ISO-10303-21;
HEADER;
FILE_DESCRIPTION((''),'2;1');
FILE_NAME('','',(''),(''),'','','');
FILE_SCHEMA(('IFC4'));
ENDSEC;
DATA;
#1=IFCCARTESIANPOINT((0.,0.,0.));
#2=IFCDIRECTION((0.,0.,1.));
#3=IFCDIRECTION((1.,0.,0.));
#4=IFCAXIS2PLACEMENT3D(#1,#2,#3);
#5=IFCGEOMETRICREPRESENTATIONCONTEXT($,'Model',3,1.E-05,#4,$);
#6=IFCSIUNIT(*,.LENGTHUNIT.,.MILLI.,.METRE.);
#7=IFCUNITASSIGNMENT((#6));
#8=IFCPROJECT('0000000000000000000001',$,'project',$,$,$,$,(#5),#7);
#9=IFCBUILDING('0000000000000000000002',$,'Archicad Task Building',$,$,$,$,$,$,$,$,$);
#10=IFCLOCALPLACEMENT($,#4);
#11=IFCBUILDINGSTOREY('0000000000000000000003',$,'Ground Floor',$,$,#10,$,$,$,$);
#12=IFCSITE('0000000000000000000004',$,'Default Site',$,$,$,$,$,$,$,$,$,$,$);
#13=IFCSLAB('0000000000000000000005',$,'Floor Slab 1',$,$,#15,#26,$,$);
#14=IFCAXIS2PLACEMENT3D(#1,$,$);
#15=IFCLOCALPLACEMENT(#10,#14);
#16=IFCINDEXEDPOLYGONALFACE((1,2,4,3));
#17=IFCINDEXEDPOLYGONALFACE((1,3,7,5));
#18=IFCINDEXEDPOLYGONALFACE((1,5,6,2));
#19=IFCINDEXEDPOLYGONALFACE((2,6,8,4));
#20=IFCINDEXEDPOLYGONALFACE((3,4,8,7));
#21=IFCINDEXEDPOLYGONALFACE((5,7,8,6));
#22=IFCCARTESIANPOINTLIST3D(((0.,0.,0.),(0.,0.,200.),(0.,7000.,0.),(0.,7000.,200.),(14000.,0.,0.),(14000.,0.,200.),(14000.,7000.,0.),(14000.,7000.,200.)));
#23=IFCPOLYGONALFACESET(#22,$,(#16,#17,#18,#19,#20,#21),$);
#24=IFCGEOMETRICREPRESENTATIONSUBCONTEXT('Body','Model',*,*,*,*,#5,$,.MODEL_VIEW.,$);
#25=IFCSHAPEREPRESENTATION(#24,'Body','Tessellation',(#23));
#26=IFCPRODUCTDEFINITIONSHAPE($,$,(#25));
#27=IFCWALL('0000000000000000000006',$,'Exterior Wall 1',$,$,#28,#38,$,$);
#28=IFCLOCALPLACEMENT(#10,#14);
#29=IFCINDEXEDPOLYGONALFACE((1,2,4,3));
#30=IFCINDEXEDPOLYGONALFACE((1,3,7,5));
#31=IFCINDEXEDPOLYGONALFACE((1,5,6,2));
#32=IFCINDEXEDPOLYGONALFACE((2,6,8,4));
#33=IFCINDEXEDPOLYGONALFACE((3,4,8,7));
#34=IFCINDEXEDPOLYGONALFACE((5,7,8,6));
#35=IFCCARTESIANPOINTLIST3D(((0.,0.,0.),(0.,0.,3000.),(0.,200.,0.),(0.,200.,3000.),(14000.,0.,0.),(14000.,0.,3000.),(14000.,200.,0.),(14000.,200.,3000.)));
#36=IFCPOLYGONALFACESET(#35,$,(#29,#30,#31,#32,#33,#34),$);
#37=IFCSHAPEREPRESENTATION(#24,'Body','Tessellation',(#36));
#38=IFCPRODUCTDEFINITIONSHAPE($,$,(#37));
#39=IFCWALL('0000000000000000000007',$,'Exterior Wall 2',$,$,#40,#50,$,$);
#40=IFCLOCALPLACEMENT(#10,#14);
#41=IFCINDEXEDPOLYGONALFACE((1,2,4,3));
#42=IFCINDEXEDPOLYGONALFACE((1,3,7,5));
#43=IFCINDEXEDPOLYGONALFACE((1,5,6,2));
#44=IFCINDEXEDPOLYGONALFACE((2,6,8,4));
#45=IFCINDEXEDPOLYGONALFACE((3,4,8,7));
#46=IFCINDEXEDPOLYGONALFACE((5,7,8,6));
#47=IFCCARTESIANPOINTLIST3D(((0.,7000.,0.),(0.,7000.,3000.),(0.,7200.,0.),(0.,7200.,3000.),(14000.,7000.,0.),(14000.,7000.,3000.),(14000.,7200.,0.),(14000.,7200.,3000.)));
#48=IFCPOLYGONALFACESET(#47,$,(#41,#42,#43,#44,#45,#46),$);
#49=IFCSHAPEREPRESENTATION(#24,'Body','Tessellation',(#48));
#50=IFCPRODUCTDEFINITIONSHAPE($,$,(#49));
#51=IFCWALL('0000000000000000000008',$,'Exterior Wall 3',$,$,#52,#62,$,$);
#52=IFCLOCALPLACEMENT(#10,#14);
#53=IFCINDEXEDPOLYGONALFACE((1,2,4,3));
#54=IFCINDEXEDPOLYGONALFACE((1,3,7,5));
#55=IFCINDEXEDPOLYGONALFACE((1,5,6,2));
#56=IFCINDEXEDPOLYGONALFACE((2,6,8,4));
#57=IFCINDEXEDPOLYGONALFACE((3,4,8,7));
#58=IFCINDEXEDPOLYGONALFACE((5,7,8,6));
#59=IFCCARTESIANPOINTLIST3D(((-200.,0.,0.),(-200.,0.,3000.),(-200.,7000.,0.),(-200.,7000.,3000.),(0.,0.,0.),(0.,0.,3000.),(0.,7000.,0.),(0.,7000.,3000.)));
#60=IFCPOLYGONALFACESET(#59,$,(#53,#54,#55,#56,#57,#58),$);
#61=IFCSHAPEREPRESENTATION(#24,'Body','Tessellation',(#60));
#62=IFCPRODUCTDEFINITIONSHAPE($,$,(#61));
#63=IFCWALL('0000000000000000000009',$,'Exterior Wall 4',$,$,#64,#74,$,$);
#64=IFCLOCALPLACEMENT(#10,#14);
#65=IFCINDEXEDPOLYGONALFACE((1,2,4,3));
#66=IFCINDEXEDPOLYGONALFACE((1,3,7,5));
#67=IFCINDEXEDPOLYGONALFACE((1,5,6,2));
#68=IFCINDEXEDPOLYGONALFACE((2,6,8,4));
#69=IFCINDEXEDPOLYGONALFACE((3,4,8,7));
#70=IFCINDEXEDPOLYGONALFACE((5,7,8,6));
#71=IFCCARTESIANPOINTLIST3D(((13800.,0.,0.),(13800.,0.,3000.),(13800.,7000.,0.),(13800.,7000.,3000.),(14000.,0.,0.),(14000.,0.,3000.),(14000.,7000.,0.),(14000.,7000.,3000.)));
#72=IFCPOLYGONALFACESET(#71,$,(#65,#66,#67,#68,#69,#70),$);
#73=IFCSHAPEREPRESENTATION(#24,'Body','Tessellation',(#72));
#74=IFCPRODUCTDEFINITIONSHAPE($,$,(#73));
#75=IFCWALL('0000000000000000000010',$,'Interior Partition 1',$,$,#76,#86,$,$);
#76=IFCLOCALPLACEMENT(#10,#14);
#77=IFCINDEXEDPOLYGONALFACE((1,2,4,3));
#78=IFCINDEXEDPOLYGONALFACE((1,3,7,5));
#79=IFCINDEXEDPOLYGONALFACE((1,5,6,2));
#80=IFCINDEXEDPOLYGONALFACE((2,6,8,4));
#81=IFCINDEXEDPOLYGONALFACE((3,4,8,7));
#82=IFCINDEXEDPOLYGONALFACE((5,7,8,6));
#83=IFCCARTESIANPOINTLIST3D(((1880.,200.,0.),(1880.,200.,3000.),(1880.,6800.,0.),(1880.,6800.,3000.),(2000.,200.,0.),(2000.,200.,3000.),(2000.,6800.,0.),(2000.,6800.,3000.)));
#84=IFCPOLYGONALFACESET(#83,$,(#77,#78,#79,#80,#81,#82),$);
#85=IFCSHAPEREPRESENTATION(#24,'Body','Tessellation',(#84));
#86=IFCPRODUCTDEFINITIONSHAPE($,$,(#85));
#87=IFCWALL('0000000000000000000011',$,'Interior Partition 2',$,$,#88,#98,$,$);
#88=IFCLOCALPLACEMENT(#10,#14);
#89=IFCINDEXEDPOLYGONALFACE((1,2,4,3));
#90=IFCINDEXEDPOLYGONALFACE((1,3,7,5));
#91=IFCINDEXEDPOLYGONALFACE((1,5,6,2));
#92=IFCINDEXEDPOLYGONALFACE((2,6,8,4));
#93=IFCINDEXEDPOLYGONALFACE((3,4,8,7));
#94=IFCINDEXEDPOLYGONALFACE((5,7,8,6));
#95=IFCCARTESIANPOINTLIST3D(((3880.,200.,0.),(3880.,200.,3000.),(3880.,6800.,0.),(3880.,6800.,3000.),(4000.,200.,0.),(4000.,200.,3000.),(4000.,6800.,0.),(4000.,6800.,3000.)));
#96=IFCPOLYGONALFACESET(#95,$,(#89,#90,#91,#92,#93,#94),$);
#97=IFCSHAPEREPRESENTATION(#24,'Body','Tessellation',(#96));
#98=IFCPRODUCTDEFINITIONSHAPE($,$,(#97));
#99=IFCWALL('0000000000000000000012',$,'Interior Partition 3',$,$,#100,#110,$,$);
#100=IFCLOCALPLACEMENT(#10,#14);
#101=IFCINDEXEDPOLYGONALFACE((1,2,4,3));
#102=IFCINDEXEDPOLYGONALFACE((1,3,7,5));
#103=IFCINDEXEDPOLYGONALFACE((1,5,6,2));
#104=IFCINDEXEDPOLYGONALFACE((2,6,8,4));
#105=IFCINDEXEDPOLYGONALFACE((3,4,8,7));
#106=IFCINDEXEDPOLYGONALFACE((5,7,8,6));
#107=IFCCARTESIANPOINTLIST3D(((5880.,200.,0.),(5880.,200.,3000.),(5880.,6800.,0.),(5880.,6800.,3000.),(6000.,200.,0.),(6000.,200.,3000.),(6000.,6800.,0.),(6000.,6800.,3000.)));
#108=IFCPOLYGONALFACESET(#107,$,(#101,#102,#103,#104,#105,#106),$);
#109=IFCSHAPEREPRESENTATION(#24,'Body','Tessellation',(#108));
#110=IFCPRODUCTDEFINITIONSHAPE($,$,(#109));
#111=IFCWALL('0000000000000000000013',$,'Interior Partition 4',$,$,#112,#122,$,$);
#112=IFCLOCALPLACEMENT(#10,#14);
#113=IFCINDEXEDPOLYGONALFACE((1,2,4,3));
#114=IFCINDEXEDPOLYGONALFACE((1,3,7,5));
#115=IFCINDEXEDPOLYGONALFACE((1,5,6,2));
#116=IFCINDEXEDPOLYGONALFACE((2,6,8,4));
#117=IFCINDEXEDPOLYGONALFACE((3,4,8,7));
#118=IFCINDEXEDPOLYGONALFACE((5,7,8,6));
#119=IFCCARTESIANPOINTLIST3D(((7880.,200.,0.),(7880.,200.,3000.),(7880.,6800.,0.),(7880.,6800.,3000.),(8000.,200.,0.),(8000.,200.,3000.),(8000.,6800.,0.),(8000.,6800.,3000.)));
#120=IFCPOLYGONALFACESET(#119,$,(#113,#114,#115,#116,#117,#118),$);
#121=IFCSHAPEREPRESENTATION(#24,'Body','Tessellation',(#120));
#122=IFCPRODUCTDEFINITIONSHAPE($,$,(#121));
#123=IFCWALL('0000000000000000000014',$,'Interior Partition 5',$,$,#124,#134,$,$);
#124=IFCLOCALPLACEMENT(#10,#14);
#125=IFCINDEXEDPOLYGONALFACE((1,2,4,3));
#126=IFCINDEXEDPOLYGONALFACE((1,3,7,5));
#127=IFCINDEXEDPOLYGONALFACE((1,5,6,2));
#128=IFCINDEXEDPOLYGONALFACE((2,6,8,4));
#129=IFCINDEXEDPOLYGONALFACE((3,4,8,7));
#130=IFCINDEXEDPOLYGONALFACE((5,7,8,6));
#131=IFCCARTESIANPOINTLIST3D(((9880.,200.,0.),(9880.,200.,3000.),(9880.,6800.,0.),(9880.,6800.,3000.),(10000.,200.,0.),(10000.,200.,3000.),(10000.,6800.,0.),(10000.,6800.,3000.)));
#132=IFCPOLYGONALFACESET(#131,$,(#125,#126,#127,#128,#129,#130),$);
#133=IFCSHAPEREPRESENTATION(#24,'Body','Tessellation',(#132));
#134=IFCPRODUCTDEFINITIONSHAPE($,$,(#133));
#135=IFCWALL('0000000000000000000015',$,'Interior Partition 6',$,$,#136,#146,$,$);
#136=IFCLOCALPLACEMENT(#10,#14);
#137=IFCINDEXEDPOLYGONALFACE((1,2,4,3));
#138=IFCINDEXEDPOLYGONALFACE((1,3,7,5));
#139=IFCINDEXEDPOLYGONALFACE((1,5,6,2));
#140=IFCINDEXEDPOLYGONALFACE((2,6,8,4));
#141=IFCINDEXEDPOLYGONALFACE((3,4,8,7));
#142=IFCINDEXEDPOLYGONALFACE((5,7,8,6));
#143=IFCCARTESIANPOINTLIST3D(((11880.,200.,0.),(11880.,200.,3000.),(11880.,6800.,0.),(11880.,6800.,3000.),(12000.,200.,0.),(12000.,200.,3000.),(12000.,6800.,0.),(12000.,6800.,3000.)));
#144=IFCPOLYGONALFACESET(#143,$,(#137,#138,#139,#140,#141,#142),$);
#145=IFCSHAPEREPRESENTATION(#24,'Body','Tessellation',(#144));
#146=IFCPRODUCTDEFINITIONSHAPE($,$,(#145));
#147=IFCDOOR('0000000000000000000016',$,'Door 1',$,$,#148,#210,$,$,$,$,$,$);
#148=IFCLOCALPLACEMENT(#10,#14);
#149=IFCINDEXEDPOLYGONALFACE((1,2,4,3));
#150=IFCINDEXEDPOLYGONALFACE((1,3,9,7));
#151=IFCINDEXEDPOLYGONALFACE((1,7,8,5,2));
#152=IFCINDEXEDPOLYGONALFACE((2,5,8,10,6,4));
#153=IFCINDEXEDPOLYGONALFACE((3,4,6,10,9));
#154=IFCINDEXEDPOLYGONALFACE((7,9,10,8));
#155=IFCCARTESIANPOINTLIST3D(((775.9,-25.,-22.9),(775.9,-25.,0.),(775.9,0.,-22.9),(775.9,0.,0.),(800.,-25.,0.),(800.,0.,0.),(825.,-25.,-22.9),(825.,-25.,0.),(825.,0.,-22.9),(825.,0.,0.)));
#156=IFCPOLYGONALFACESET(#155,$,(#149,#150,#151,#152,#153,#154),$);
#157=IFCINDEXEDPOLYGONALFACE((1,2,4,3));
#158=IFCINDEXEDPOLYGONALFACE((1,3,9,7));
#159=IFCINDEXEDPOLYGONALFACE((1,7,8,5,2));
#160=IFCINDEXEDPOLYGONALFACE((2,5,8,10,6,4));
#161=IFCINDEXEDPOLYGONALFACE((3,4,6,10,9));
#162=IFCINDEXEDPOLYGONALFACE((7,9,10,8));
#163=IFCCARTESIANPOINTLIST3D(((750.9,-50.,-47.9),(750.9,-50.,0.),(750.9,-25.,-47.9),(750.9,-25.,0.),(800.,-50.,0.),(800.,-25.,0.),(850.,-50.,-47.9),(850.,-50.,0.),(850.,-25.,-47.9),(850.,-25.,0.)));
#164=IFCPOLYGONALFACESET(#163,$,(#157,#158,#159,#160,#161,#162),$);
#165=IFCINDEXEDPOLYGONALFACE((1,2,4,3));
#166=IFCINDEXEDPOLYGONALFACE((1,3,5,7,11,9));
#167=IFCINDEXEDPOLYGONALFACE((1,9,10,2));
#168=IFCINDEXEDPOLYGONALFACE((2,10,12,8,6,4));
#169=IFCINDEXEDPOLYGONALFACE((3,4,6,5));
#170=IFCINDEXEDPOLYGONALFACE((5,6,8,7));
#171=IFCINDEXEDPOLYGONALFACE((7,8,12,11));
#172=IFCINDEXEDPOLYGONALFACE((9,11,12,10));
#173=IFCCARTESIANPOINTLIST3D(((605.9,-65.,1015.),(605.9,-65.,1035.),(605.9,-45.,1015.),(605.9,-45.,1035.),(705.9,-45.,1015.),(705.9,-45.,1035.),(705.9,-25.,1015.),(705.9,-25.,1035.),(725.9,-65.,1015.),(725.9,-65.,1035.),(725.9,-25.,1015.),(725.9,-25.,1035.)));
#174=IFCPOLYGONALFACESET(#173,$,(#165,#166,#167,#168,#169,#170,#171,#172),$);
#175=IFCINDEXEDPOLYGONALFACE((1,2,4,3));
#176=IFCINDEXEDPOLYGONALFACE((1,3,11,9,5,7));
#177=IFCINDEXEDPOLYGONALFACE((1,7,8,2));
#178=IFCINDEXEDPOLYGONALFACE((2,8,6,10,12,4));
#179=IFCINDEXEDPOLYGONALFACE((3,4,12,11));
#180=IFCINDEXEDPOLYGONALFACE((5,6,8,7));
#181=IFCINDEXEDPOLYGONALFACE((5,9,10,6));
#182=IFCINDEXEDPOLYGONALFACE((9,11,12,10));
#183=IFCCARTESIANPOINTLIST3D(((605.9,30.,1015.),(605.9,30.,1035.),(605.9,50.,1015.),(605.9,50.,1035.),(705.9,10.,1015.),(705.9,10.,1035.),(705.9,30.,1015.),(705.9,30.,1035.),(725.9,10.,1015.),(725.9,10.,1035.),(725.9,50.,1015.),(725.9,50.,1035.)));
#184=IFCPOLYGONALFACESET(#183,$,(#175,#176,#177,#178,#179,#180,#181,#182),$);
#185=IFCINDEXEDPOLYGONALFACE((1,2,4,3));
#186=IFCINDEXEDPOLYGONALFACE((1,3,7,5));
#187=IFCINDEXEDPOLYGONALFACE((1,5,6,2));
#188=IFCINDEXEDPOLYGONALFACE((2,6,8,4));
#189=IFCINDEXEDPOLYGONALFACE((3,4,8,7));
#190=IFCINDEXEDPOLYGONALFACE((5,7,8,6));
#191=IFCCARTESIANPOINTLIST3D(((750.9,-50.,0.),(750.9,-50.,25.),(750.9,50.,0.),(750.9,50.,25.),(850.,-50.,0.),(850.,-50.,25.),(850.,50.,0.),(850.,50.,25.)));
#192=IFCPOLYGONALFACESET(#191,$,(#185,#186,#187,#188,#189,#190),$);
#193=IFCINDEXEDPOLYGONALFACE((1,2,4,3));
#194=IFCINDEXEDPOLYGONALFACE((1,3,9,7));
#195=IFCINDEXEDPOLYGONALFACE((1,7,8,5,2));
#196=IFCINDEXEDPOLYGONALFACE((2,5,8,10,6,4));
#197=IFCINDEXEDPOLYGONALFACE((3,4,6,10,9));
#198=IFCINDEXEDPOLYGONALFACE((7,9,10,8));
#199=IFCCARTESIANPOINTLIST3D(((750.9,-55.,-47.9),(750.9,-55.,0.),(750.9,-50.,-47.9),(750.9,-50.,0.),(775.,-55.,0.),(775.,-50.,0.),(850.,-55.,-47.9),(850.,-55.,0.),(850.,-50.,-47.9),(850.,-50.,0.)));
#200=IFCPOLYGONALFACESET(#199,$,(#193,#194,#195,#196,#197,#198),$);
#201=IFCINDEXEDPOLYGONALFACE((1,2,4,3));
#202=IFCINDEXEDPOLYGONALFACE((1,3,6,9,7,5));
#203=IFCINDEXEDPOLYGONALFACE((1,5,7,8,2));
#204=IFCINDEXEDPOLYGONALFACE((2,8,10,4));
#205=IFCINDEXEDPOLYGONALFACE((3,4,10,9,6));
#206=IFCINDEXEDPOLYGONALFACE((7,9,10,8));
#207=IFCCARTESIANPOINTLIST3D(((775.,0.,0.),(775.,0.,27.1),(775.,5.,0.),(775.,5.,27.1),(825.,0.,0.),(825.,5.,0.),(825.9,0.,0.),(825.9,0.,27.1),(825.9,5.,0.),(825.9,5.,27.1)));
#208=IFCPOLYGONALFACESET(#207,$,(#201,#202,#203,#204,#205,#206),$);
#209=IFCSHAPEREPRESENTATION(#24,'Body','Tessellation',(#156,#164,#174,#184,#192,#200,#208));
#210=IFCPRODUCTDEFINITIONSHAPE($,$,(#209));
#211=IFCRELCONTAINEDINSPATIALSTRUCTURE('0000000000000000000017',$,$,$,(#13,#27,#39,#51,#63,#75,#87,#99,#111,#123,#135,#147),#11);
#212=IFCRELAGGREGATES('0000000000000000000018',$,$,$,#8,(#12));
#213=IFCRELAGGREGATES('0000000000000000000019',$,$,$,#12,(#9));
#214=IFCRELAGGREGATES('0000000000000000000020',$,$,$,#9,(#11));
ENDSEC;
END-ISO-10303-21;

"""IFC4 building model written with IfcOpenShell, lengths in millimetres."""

from ifc_helpers import new_model, si_unit, frame, origin_with_axes, place, context, subcontext, project, spatial, line, indexed_curve, outline, extrude, element, save


model = new_model("IFC4")

# Units and contexts
model_context = context("Model", 3, precision=1e-05, world=origin_with_axes())
body_context = subcontext(model_context, "Body", "Model", "MODEL_VIEW")
ifc_project = project(units=[si_unit("LENGTHUNIT", "METRE", prefix="MILLI")], contexts=[model_context])

# Site, building, storey
site = spatial("IfcSite", under=ifc_project, Name="Default Site")
building = spatial("IfcBuilding", under=site, Name="Archicad Task Building")
storey_placement = place(None, origin_with_axes())
storey = spatial("IfcBuildingStorey", under=building, at=storey_placement, Name="Ground Floor")

# Slab
slab_placement = place(storey_placement, origin_with_axes())
element("IfcSlab", 1, at=slab_placement, inside=storey, Name="Floor Slab 1", context=body_context, shape_type="SweptSolid", body=[
    extrude(outline(indexed_curve([(0.0, 0.0), (14000.0, 0.0), (14000.0, 7000.0), (0.0, 7000.0), (0.0, 0.0)])), None, (0.0, 0.0, 1.0), 200.0),
])

# Walls
for number, where, z_axis, x_axis, name in (
    (2, (0.0, 0.0, 0.0), (0.0, 0.0, 1.0), (1.0, 0.0, 0.0), "Exterior Wall 1"),
    (3, (0.0, 7000.0, 0.0), (0.0, 0.0, 1.0), (1.0, 0.0, 0.0), "Exterior Wall 2"),
):
    element("IfcWall", number, at=place(storey_placement, frame(where, z_axis=z_axis, x_axis=x_axis)), inside=storey, Name=name, context=body_context, shape_type="SweptSolid", body=[
        extrude(outline(indexed_curve([(0.0, 0.0), (0.0, 200.0), (14000.0, 200.0), (14000.0, 0.0), (0.0, 0.0)], self_intersect=False)), origin_with_axes(), (0.0, 0.0, 1.0), 3000.0),
    ])
for number, where, z_axis, x_axis, name in (
    (4, (0.0, 0.0, 0.0), (0.0, 0.0, 1.0), (0.0, 1.0, 0.0), "Exterior Wall 3"),
    (5, (14000.0, 0.0, 0.0), (0.0, 0.0, 1.0), (0.0, 1.0, 0.0), "Exterior Wall 4"),
):
    element("IfcWall", number, at=place(storey_placement, frame(where, z_axis=z_axis, x_axis=x_axis)), inside=storey, Name=name, context=body_context, shape_type="SweptSolid", body=[
        extrude(outline(indexed_curve([(0.0, 0.0), (0.0, 200.0), (7000.0, 200.0), (7000.0, 0.0), (0.0, 0.0)], self_intersect=False)), origin_with_axes(), (0.0, 0.0, 1.0), 3000.0),
    ])
for number, where, z_axis, x_axis, name in (
    (6, (2000.0, 200.0, 0.0), (0.0, 0.0, 1.0), (0.0, 1.0, 0.0), "Interior Partition 1"),
    (7, (4000.0, 200.0, 0.0), (0.0, 0.0, 1.0), (0.0, 1.0, 0.0), "Interior Partition 2"),
    (8, (6000.0, 200.0, 0.0), (0.0, 0.0, 1.0), (0.0, 1.0, 0.0), "Interior Partition 3"),
    (9, (8000.0, 200.0, 0.0), (0.0, 0.0, 1.0), (0.0, 1.0, 0.0), "Interior Partition 4"),
    (10, (10000.0, 200.0, 0.0), (0.0, 0.0, 1.0), (0.0, 1.0, 0.0), "Interior Partition 5"),
    (11, (12000.0, 200.0, 0.0), (0.0, 0.0, 1.0), (0.0, 1.0, 0.0), "Interior Partition 6"),
):
    element("IfcWall", number, at=place(storey_placement, frame(where, z_axis=z_axis, x_axis=x_axis)), inside=storey, Name=name, context=body_context, shape_type="SweptSolid", body=[
        extrude(outline(indexed_curve([(0.0, 0.0), (0.0, 120.0), (6600.0, 120.0), (6600.0, 0.0), (0.0, 0.0)], self_intersect=False)), origin_with_axes(), (0.0, 0.0, 1.0), 3000.0),
    ])

# Door
door_1_placement = place(storey_placement, frame((800.0, -50.0, 0.0), z_axis=(0.0, 0.0, 1.0), x_axis=(1.0, 0.0, 0.0)))
element("IfcDoor", 12, at=door_1_placement, inside=storey, Name="Door 1", context=body_context, shape_type="SweptSolid", body=[
    extrude(outline(indexed_curve([(0.0, 0.0), (0.0, 2.1), (0.9, 2.1), (0.9, 0.0), (-24.1, 0.0), (-24.1, -22.9), (25.0, -22.9), (25.0, 0.0)], segments=[line(1, 2, 3, 4, 5, 6, 7, 8, 1)])), frame((0.0, 25.0, 0.0), z_axis=(0.0, -1.0, 0.0), x_axis=(1.0, 0.0, 0.0)), (0.0, 0.0, -1.0), 25.0),
    extrude(outline(indexed_curve([(0.0, 0.0), (0.0, 2.1), (0.9, 2.1), (0.9, 0.0), (-49.1, 0.0), (-49.1, -47.9), (50.0, -47.9), (50.0, 0.0)], segments=[line(1, 2, 3, 4, 5, 6, 7, 8, 1)])), frame((0.0, 0.0, 0.0), z_axis=(0.0, -1.0, 0.0), x_axis=(1.0, 0.0, 0.0)), (0.0, 0.0, -1.0), 25.0),
    extrude(outline(indexed_curve([(0.0, 0.0), (-49.1, 0.0), (-49.1, 35.0), (0.0, 35.0)], segments=[line(1, 2, 3, 4, 1)])), frame((25.0, 25.0, 25.0), z_axis=(0.0, 0.0, 1.0), x_axis=(1.0, 0.0, 0.0)), (0.0, 0.0, 1.0), -47.9),
    extrude(outline(indexed_curve([(0.0, 0.0), (0.0, -40.0), (-120.0, -40.0), (-120.0, -20.0), (-20.0, -20.0), (-20.0, 0.0)], segments=[line(1, 2, 3, 4, 5, 6, 1)])), frame((-74.1, 25.0, 1015.0), z_axis=(0.0, 0.0, 1.0), x_axis=(1.0, 0.0, 0.0)), (0.0, 0.0, 1.0), 20.0),
    extrude(outline(indexed_curve([(0.0, 0.0), (0.0, 40.0), (-120.0, 40.0), (-120.0, 20.0), (-20.0, 20.0), (-20.0, 0.0)], segments=[line(1, 2, 3, 4, 5, 6, 1)])), frame((-74.1, 60.0, 1015.0), z_axis=(0.0, 0.0, 1.0), x_axis=(1.0, 0.0, 0.0)), (0.0, 0.0, 1.0), 20.0),
    extrude(outline(indexed_curve([(0.0, 0.0), (-99.1, 0.0), (-99.1, 100.0), (0.0, 100.0)], segments=[line(1, 2, 3, 4, 1)])), frame((50.0, 0.0, 0.0), z_axis=(0.0, 0.0, 1.0), x_axis=(1.0, 0.0, 0.0)), (0.0, 0.0, 1.0), 25.0),
    extrude(outline(indexed_curve([(0.0, 0.0), (0.0, 27.1), (50.9, 27.1), (50.9, 0.0), (-24.1, 0.0), (-24.1, -47.9), (75.0, -47.9), (75.0, 0.0)], segments=[line(1, 2, 3, 4, 5, 6, 7, 8, 1)])), frame((-25.0, -5.0, 0.0), z_axis=(0.0, -1.0, 0.0), x_axis=(1.0, 0.0, 0.0)), (0.0, 0.0, -1.0), 5.0),
    extrude(outline(indexed_curve([(0.0, 0.0), (0.0, 27.1), (50.9, 27.1), (50.9, 0.0), (0.9, 0.0), (0.9, -22.9), (50.0, -22.9), (50.0, 0.0)], segments=[line(1, 2, 3, 4, 5, 6, 7, 8, 1)])), frame((-25.0, 50.0, 0.0), z_axis=(0.0, -1.0, 0.0), x_axis=(1.0, 0.0, 0.0)), (0.0, 0.0, -1.0), 5.0),
])

save(model, "model.ifc")
